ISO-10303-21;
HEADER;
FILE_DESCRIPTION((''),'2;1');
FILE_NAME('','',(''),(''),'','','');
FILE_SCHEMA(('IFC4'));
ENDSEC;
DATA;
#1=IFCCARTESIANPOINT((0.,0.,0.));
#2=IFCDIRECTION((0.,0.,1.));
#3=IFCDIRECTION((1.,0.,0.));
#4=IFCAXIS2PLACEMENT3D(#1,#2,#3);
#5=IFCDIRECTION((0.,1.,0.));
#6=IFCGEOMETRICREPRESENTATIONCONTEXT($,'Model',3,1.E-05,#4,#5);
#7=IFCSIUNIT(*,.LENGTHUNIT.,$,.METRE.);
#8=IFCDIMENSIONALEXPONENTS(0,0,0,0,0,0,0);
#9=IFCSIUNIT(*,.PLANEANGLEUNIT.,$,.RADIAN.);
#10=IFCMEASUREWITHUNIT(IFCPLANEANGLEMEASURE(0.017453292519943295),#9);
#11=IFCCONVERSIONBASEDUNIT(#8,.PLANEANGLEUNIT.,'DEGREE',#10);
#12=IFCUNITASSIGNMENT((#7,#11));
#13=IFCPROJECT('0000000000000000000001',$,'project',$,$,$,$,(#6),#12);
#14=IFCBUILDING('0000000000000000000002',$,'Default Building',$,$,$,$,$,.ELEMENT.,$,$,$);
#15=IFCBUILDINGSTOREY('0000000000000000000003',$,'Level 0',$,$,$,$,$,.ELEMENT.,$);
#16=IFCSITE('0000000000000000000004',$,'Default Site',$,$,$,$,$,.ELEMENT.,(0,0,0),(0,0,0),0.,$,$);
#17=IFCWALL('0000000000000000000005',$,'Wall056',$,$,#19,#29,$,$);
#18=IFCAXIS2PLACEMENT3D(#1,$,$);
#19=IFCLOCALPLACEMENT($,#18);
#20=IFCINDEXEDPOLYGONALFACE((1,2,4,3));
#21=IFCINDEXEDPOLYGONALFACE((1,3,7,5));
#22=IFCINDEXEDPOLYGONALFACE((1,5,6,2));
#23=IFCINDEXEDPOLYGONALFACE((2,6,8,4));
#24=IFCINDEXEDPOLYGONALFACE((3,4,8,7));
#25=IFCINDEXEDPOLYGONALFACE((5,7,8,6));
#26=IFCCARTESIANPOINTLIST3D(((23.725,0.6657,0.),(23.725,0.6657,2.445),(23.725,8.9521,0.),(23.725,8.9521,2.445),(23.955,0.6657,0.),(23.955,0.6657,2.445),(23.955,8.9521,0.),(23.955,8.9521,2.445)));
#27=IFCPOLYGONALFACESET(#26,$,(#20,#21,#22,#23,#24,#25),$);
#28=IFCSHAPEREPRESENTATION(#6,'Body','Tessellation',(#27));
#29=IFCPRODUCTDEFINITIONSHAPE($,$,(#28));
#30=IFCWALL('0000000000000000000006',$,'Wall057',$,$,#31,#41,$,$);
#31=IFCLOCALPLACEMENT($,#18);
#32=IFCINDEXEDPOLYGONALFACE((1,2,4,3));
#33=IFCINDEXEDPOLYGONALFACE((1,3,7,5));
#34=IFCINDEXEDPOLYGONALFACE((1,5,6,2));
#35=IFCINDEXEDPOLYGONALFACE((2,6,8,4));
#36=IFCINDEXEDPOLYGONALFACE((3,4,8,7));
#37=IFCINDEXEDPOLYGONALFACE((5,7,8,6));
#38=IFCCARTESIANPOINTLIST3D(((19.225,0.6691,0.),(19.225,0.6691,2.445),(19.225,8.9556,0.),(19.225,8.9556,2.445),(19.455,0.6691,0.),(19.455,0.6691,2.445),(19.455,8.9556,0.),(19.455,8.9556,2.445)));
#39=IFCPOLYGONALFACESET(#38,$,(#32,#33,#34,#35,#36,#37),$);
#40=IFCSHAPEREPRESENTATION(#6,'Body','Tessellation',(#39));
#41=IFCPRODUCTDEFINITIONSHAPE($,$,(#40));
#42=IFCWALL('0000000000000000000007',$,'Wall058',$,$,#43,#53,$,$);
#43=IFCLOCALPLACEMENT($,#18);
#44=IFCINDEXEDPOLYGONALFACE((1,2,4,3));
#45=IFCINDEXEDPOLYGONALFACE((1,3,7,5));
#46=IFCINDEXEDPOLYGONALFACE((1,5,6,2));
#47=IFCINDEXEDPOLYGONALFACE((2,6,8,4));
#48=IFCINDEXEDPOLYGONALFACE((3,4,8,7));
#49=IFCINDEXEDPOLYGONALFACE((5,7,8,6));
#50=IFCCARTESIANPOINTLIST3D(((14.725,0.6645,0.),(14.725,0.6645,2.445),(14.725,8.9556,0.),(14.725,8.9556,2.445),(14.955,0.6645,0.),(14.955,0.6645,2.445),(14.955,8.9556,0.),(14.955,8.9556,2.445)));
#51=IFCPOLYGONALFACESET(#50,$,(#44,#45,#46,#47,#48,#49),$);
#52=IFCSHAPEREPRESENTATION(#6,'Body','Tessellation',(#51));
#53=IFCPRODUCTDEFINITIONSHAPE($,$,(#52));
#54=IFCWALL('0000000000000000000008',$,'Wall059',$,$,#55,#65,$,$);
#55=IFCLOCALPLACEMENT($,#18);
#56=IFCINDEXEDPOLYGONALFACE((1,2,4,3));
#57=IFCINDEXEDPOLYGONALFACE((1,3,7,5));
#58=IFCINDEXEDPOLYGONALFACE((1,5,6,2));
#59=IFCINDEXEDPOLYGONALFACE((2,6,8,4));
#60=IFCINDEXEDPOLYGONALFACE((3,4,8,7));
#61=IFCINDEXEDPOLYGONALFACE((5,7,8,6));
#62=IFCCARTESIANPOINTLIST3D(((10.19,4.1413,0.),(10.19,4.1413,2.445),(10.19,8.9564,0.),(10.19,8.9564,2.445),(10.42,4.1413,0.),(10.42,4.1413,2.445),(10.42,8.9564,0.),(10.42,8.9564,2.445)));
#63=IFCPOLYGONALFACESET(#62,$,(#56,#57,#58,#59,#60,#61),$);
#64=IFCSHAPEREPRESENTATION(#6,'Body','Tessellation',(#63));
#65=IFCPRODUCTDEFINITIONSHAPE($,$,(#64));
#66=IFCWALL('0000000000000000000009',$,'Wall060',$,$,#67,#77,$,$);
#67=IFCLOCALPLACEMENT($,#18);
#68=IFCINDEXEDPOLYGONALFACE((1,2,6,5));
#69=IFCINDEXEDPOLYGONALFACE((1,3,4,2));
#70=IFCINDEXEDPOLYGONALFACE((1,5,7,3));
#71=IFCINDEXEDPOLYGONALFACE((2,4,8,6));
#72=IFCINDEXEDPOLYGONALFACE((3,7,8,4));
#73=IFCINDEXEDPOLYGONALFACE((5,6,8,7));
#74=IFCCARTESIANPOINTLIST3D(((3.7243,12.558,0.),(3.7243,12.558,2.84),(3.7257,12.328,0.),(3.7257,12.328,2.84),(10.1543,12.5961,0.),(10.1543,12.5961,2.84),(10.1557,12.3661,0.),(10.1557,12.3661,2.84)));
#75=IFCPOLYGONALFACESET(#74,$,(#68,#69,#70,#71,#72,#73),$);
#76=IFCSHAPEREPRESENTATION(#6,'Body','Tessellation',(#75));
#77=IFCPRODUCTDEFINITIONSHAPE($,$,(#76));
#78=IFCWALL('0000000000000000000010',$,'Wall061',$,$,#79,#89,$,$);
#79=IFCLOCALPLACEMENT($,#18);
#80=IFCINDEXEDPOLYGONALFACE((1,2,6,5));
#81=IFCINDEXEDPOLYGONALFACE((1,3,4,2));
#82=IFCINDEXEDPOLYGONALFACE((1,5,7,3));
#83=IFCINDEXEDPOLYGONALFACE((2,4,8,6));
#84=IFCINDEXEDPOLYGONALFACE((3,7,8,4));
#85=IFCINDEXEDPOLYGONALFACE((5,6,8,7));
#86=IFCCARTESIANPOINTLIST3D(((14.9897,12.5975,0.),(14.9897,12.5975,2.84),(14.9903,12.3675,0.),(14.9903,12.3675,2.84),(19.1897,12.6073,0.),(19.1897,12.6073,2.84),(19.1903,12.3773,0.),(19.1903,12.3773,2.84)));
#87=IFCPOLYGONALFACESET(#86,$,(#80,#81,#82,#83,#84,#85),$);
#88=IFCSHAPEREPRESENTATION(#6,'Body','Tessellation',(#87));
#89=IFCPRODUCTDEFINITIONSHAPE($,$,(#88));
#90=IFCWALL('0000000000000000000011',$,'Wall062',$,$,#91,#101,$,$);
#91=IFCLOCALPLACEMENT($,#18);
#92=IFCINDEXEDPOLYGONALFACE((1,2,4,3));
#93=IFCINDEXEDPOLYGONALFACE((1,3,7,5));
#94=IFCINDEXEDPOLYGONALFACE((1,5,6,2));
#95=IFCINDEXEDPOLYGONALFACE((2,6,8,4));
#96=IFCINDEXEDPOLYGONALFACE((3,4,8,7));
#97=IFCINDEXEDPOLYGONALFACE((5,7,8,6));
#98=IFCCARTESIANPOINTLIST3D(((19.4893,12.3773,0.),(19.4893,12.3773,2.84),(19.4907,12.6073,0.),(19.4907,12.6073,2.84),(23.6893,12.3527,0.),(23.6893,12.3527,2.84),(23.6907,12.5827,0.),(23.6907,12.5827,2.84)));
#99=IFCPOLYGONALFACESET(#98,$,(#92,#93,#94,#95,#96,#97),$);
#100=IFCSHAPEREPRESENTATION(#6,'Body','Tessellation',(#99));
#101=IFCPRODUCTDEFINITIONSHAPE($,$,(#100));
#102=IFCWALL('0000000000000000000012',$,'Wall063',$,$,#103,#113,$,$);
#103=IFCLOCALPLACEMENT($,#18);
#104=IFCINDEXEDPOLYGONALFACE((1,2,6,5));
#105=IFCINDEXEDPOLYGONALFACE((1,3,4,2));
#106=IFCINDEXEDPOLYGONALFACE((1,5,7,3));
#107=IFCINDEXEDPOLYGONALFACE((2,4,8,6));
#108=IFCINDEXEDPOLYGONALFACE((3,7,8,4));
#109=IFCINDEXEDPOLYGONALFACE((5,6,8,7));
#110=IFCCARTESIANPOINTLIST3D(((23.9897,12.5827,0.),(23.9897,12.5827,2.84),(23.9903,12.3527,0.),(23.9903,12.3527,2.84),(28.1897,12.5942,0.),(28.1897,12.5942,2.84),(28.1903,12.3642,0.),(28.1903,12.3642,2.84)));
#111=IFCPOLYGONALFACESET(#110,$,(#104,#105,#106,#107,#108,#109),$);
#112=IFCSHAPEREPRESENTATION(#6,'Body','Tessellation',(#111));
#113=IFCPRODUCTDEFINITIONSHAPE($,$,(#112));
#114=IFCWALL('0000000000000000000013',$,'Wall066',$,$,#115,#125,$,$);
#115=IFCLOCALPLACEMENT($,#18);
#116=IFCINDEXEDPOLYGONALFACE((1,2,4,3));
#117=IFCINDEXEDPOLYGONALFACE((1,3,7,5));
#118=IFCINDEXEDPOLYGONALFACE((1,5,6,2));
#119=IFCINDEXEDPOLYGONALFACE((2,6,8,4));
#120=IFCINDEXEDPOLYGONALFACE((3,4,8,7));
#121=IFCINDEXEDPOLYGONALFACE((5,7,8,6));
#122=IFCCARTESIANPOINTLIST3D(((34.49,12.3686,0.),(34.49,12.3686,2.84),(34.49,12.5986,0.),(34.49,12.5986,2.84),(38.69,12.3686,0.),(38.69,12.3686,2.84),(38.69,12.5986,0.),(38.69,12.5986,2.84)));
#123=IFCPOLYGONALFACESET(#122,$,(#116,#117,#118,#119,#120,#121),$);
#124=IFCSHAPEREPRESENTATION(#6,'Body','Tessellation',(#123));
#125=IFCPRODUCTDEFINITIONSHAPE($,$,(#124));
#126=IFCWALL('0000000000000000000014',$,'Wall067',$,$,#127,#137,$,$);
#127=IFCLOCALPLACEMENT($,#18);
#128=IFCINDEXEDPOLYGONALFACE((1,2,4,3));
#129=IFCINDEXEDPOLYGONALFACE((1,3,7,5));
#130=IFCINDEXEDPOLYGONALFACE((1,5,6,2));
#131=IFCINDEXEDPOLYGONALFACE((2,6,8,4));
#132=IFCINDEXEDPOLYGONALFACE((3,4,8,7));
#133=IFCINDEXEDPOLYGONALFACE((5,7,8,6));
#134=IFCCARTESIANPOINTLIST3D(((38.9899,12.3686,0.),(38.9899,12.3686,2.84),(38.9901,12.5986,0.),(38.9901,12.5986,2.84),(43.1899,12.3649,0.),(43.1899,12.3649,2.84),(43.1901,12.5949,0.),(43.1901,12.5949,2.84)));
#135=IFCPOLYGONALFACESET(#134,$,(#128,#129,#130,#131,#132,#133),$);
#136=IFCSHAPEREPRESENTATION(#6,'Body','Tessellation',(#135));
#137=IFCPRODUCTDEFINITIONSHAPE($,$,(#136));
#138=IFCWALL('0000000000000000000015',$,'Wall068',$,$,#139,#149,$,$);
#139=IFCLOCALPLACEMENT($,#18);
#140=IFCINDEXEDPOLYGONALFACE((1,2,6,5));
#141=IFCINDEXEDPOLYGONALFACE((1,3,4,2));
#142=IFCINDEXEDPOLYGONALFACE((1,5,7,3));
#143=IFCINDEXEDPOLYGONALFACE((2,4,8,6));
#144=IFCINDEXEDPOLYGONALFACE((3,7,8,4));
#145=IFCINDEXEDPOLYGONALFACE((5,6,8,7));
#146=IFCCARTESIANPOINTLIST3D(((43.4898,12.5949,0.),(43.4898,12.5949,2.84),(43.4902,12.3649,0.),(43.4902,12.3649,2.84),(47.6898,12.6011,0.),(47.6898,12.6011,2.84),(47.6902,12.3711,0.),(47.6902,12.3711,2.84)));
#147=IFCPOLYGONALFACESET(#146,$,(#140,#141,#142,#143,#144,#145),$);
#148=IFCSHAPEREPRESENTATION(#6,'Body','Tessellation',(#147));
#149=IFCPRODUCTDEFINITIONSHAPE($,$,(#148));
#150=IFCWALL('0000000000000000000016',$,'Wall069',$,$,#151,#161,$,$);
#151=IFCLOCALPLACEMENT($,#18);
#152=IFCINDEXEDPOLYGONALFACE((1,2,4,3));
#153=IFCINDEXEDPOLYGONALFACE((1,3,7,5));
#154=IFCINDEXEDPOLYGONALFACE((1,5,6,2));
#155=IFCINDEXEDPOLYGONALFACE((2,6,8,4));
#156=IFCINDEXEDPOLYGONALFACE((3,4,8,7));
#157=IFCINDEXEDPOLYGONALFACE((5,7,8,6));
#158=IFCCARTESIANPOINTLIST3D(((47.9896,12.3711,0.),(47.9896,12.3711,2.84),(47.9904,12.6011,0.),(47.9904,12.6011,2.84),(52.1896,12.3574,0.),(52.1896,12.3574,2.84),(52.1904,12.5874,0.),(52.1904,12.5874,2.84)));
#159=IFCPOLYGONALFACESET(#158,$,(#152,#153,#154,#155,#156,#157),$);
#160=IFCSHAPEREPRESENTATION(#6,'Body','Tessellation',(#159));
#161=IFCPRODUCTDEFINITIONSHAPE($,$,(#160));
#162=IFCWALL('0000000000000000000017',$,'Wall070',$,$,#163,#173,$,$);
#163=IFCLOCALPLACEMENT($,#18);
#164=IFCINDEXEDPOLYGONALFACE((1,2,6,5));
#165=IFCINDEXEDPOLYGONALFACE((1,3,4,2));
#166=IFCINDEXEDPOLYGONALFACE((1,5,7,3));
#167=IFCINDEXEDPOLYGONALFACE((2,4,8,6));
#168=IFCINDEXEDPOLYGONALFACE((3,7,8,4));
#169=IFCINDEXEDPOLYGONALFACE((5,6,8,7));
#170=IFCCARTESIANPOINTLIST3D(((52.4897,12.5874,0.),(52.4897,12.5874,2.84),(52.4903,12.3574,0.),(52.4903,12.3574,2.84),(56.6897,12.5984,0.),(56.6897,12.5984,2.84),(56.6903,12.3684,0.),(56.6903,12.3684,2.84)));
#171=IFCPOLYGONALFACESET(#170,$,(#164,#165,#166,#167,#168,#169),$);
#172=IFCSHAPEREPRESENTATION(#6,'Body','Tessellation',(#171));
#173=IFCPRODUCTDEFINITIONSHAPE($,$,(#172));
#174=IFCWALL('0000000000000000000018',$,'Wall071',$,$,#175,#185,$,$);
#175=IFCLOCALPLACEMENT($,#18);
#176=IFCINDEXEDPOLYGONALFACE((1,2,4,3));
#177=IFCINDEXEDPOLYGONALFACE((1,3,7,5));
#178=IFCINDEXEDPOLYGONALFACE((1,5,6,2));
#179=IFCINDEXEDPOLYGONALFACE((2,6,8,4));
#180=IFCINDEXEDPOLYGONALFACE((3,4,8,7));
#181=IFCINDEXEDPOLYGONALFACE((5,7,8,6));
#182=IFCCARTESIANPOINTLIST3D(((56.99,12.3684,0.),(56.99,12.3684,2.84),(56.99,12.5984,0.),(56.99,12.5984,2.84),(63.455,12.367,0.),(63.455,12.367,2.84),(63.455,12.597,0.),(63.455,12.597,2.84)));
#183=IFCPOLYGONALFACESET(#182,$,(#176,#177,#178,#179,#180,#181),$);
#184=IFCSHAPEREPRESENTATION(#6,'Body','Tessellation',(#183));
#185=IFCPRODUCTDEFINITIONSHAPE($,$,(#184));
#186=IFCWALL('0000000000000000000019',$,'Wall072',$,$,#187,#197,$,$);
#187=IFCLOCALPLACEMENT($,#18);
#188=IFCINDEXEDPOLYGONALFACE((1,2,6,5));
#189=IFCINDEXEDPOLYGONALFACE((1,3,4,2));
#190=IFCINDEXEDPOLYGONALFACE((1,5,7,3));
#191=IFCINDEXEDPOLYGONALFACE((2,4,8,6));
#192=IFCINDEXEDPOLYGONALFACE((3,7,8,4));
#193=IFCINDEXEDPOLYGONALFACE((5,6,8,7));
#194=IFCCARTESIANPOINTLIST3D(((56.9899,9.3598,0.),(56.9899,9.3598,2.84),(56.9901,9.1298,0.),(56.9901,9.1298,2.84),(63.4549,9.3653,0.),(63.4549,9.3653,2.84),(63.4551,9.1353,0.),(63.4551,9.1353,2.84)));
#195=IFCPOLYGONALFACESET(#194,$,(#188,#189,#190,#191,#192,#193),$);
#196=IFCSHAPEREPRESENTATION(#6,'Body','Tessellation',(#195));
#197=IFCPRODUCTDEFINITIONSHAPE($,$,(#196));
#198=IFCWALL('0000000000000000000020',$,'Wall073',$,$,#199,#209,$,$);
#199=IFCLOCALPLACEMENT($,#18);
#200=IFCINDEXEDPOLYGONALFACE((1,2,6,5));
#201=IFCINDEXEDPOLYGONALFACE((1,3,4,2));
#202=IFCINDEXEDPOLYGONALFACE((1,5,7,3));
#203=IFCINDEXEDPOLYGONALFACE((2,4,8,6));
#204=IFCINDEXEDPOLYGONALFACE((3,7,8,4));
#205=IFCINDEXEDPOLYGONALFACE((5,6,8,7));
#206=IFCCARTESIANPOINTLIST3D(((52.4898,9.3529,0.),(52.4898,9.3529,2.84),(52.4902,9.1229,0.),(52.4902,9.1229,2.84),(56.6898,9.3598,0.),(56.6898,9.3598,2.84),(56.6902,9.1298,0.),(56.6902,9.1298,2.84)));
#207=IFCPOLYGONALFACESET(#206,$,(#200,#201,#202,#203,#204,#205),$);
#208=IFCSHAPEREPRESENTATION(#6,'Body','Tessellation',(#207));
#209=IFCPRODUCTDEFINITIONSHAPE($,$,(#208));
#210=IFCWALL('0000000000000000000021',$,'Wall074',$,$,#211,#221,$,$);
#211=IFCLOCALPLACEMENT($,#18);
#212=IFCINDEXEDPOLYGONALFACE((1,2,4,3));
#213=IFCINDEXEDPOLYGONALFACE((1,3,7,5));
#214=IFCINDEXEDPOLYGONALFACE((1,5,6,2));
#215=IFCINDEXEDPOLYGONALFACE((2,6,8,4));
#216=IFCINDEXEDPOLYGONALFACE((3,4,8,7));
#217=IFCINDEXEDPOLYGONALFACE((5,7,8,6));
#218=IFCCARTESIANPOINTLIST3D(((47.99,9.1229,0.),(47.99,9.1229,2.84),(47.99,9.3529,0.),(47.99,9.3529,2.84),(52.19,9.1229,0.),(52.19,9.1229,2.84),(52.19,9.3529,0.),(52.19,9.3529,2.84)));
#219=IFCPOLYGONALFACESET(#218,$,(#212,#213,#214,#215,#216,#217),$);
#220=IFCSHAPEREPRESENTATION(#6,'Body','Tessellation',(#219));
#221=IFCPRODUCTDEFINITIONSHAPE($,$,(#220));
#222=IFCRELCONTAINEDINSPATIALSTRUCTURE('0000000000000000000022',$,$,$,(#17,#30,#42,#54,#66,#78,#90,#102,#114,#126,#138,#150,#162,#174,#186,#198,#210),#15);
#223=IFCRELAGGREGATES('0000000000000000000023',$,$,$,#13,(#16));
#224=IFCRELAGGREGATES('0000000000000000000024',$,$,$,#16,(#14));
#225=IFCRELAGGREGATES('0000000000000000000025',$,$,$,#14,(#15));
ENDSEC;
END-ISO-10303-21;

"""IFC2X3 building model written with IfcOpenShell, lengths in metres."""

from ifc_helpers import new_model, entity, si_unit, converted_unit, direction, frame, frame_2d, origin_with_axes, place, context, project, spatial, rectangle, extrude, element, save


model = new_model("IFC2X3")

# Units and contexts
model_context = context("Model", 3, precision=1e-05, world=origin_with_axes(), true_north=direction((0.0, 1.0, 0.0)))
ifc_project = project(units=[si_unit("LENGTHUNIT", "METRE"), converted_unit("PLANEANGLEUNIT", "DEGREE", entity("IfcPlaneAngleMeasure", 0.017453292519943295), si_unit("PLANEANGLEUNIT", "RADIAN"), dimensions=[0, 0, 0, 0, 0, 0, 0])], contexts=[model_context])

# Site, building, storey
site = spatial("IfcSite", under=ifc_project, Name="Default Site", CompositionType="ELEMENT", RefLatitude=(0, 0, 0), RefLongitude=(0, 0, 0), RefElevation=0.0)
building = spatial("IfcBuilding", under=site, Name="Default Building", CompositionType="ELEMENT")
storey = spatial("IfcBuildingStorey", under=building, Name="Level 0", CompositionType="ELEMENT")

# Walls
placement = place(None, origin_with_axes())
element("IfcWall", 1, at=placement, inside=storey, Name="Wall056", context=model_context, shape_type="SweptSolid", body=[
    extrude(rectangle(XDim=8.2865, YDim=0.23, at=frame_2d((0.0, 0.0), x_axis=(0.0, -1.0, 0.0))), frame((23.84, 4.8089, 0.0), z_axis=(0.0, 0.0, 1.0), x_axis=(1.0, 0.0, 0.0)), (0.0, 0.0, 1.0), 2.445),
])
element("IfcWall", 2, at=placement, inside=storey, Name="Wall057", context=model_context, shape_type="SweptSolid", body=[
    extrude(rectangle(XDim=8.2866, YDim=0.23, at=frame_2d((0.0, 0.0), x_axis=(0.0, 1.0, 0.0))), frame((19.34, 4.8124, 0.0), z_axis=(0.0, 0.0, 1.0), x_axis=(1.0, 0.0, 0.0)), (0.0, 0.0, 1.0), 2.445),
])
element("IfcWall", 3, at=placement, inside=storey, Name="Wall058", context=model_context, shape_type="SweptSolid", body=[
    extrude(rectangle(XDim=8.291, YDim=0.23, at=frame_2d((0.0, 0.0), x_axis=(0.0, -1.0, 0.0))), frame((14.84, 4.81, 0.0), z_axis=(0.0, 0.0, 1.0), x_axis=(1.0, 0.0, 0.0)), (0.0, 0.0, 1.0), 2.445),
])
element("IfcWall", 4, at=placement, inside=storey, Name="Wall059", context=model_context, shape_type="SweptSolid", body=[
    extrude(rectangle(XDim=4.8151, YDim=0.23, at=frame_2d((0.0, 0.0), x_axis=(0.0, 1.0, 0.0))), frame((10.305, 6.5488, 0.0), z_axis=(0.0, 0.0, 1.0), x_axis=(1.0, 0.0, 0.0)), (0.0, 0.0, 1.0), 2.445),
])
element("IfcWall", 5, at=placement, inside=storey, Name="Wall060", context=model_context, shape_type="SweptSolid", body=[
    extrude(rectangle(XDim=6.4301, YDim=0.23, at=frame_2d((0.0, 0.0), x_axis=(0.999982, 0.005918, 0.0))), frame((6.94, 12.4621, 0.0), z_axis=(0.0, 0.0, 1.0), x_axis=(1.0, 0.0, 0.0)), (0.0, 0.0, 1.0), 2.84),
])
element("IfcWall", 6, at=placement, inside=storey, Name="Wall061", context=model_context, shape_type="SweptSolid", body=[
    extrude(rectangle(XDim=4.2, YDim=0.23, at=frame_2d((0.0, 0.0), x_axis=(-0.999997, -0.002332, 0.0))), frame((17.09, 12.4874, 0.0), z_axis=(0.0, 0.0, 1.0), x_axis=(1.0, 0.0, 0.0)), (0.0, 0.0, 1.0), 2.84),
])
element("IfcWall", 7, at=placement, inside=storey, Name="Wall062", context=model_context, shape_type="SweptSolid", body=[
    extrude(rectangle(XDim=4.2001, YDim=0.23, at=frame_2d((0.0, 0.0), x_axis=(0.999983, -0.005853, 0.0))), frame((21.59, 12.48, 0.0), z_axis=(0.0, 0.0, 1.0), x_axis=(1.0, 0.0, 0.0)), (0.0, 0.0, 1.0), 2.84),
])
element("IfcWall", 8, at=placement, inside=storey, Name="Wall063", context=model_context, shape_type="SweptSolid", body=[
    extrude(rectangle(XDim=4.2, YDim=0.23, at=frame_2d((0.0, 0.0), x_axis=(-0.999996, -0.002734, 0.0))), frame((26.09, 12.4734, 0.0), z_axis=(0.0, 0.0, 1.0), x_axis=(1.0, 0.0, 0.0)), (0.0, 0.0, 1.0), 2.84),
])
element("IfcWall", 9, at=placement, inside=storey, Name="Wall066", context=model_context, shape_type="SweptSolid", body=[
    extrude(rectangle(XDim=4.2, YDim=0.23, at=frame_2d((0.0, 0.0), x_axis=(-1.0, 0.000008, 0.0))), frame((36.59, 12.4836, 0.0), z_axis=(0.0, 0.0, 1.0), x_axis=(1.0, 0.0, 0.0)), (0.0, 0.0, 1.0), 2.84),
])
element("IfcWall", 10, at=placement, inside=storey, Name="Wall067", context=model_context, shape_type="SweptSolid", body=[
    extrude(rectangle(XDim=4.2, YDim=0.23, at=frame_2d((0.0, 0.0), x_axis=(1.0, -0.000885, 0.0))), frame((41.09, 12.4817, 0.0), z_axis=(0.0, 0.0, 1.0), x_axis=(1.0, 0.0, 0.0)), (0.0, 0.0, 1.0), 2.84),
])
element("IfcWall", 11, at=placement, inside=storey, Name="Wall068", context=model_context, shape_type="SweptSolid", body=[
    extrude(rectangle(XDim=4.2, YDim=0.23, at=frame_2d((0.0, 0.0), x_axis=(-0.999999, -0.001472, 0.0))), frame((45.59, 12.483, 0.0), z_axis=(0.0, 0.0, 1.0), x_axis=(1.0, 0.0, 0.0)), (0.0, 0.0, 1.0), 2.84),
])
element("IfcWall", 12, at=placement, inside=storey, Name="Wall069", context=model_context, shape_type="SweptSolid", body=[
    extrude(rectangle(XDim=4.2, YDim=0.23, at=frame_2d((0.0, 0.0), x_axis=(0.999995, -0.003262, 0.0))), frame((50.09, 12.4792, 0.0), z_axis=(0.0, 0.0, 1.0), x_axis=(1.0, 0.0, 0.0)), (0.0, 0.0, 1.0), 2.84),
])
element("IfcWall", 13, at=placement, inside=storey, Name="Wall070", context=model_context, shape_type="SweptSolid", body=[
    extrude(rectangle(XDim=4.2, YDim=0.23, at=frame_2d((0.0, 0.0), x_axis=(-0.999997, -0.002631, 0.0))), frame((54.59, 12.4779, 0.0), z_axis=(0.0, 0.0, 1.0), x_axis=(1.0, 0.0, 0.0)), (0.0, 0.0, 1.0), 2.84),
])
element("IfcWall", 14, at=placement, inside=storey, Name="Wall071", context=model_context, shape_type="SweptSolid", body=[
    extrude(rectangle(XDim=6.465, YDim=0.23, at=frame_2d((0.0, 0.0), x_axis=(1.0, -0.000226, 0.0))), frame((60.2225, 12.4827, 0.0), z_axis=(0.0, 0.0, 1.0), x_axis=(1.0, 0.0, 0.0)), (0.0, 0.0, 1.0), 2.84),
])
element("IfcWall", 15, at=placement, inside=storey, Name="Wall072", context=model_context, shape_type="SweptSolid", body=[
    extrude(rectangle(XDim=6.465, YDim=0.23, at=frame_2d((0.0, 0.0), x_axis=(-1.0, -0.000853, 0.0))), frame((60.2225, 9.2476, 0.0), z_axis=(0.0, 0.0, 1.0), x_axis=(1.0, 0.0, 0.0)), (0.0, 0.0, 1.0), 2.84),
])
element("IfcWall", 16, at=placement, inside=storey, Name="Wall073", context=model_context, shape_type="SweptSolid", body=[
    extrude(rectangle(XDim=4.2, YDim=0.23, at=frame_2d((0.0, 0.0), x_axis=(0.999999, 0.001646, 0.0))), frame((54.59, 9.2414, 0.0), z_axis=(0.0, 0.0, 1.0), x_axis=(1.0, 0.0, 0.0)), (0.0, 0.0, 1.0), 2.84),
])
element("IfcWall", 17, at=placement, inside=storey, Name="Wall074", context=model_context, shape_type="SweptSolid", body=[
    extrude(rectangle(XDim=4.2, YDim=0.23, at=frame_2d((0.0, 0.0), x_axis=(-1.0, 0.0, 0.0))), frame((50.09, 9.2379, 0.0), z_axis=(0.0, 0.0, 1.0), x_axis=(1.0, 0.0, 0.0)), (0.0, 0.0, 1.0), 2.84),
])

save(model, "model.ifc")
